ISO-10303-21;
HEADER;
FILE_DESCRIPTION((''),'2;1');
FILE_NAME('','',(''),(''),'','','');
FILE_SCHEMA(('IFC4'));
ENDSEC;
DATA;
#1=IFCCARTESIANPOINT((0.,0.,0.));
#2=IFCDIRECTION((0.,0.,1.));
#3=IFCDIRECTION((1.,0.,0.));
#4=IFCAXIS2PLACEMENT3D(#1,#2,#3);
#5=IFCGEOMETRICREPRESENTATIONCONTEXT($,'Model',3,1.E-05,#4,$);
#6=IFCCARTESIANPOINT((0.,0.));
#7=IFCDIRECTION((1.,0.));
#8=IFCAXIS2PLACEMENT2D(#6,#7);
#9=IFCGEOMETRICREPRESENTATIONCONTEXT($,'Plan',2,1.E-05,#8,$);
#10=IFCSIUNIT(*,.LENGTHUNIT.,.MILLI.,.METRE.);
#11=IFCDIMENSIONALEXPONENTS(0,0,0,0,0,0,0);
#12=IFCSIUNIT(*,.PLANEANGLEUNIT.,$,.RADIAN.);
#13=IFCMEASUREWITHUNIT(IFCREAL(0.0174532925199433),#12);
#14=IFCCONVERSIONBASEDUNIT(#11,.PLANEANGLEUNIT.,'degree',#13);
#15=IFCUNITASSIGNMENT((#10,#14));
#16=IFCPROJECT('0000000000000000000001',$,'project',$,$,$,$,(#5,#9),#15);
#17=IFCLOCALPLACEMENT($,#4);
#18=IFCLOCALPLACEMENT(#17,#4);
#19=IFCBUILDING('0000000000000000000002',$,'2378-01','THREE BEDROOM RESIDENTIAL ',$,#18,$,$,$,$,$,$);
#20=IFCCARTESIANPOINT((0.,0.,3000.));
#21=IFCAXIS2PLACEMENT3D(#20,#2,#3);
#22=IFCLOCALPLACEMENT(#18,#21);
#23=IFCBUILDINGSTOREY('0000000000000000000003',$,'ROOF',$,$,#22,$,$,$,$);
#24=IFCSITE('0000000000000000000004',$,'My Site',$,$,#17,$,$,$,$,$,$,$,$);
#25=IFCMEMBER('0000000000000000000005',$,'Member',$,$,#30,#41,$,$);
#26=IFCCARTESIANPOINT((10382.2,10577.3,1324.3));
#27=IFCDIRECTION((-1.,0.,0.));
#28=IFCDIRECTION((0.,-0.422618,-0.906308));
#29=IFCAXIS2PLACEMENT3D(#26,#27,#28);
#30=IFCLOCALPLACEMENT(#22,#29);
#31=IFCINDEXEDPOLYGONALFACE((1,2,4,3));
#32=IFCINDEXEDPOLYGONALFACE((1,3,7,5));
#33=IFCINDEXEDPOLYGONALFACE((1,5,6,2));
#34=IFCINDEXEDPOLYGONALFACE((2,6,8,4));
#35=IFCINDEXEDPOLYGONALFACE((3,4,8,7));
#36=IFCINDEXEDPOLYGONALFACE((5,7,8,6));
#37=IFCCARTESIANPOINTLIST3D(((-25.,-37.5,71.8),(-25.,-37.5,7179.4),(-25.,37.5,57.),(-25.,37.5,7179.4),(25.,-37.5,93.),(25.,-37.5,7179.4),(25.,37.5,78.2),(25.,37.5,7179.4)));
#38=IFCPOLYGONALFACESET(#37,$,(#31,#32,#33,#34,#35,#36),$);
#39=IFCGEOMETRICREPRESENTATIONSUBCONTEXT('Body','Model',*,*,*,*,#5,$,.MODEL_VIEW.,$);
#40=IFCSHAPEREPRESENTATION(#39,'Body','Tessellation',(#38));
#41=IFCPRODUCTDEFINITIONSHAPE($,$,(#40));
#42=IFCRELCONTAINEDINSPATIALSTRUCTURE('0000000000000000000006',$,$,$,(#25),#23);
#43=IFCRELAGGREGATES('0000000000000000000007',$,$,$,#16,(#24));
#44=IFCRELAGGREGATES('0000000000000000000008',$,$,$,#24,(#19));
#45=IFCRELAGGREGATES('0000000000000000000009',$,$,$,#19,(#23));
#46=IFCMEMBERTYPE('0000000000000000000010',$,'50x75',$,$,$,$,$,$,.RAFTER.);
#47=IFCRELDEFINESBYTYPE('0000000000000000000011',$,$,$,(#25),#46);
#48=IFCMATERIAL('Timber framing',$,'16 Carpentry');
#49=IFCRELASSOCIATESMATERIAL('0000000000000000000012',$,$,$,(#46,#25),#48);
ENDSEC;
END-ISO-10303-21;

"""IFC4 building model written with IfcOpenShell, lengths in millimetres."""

from ifc_helpers import new_model, entity, si_unit, converted_unit, frame, origin_with_axes, origin_2d_with_axis, place, context, subcontext, project, spatial, rectangle, extrude, clip, halfspace, material, material_profile, profile_set, profile_usage, type_object, element, save


model = new_model("IFC4")

# Units and contexts
model_context = context("Model", 3, precision=1e-05, world=origin_with_axes())
plan_context = context("Plan", 2, precision=1e-05, world=origin_2d_with_axis())
body_context = subcontext(model_context, "Body", "Model", "MODEL_VIEW")
ifc_project = project(units=[si_unit("LENGTHUNIT", "METRE", prefix="MILLI"), converted_unit("PLANEANGLEUNIT", "degree", entity("IfcReal", 0.0174532925199433), si_unit("PLANEANGLEUNIT", "RADIAN"), dimensions=[0, 0, 0, 0, 0, 0, 0])], contexts=[model_context, plan_context])

# Site, building, storey
site_placement = place(None, origin_with_axes())
site = spatial("IfcSite", under=ifc_project, at=site_placement, Name="My Site")
building_placement = place(site_placement, origin_with_axes())
building = spatial("IfcBuilding", under=site, at=building_placement, Name="2378-01", Description="THREE BEDROOM RESIDENTIAL ")
storey_placement = place(building_placement, frame((0.0, 0.0, 3000.0), z_axis=(0.0, 0.0, 1.0), x_axis=(1.0, 0.0, 0.0)))
storey = spatial("IfcBuildingStorey", under=building, at=storey_placement, Name="ROOF")

# Member
ifc_material_1 = material(Name="Timber framing", Category="16 Carpentry")
ifc_material_profile_1 = material_profile(ifc_material_1, rectangle(XDim=50.0, YDim=75.0), Name="Lumber2", Category="Substrate", Priority=2)
ifc_profile_set_1 = profile_set([ifc_material_profile_1])
member_type_1 = type_object("IfcMemberType", Name="50x75", PredefinedType="RAFTER", material=ifc_profile_set_1)
ifc_profile_usage_1 = profile_usage(ifc_profile_set_1, cardinal=5)
member_1_placement = place(storey_placement, frame((10382.2, 10577.3, 1324.3), z_axis=(-1.0, 0.0, 0.0), x_axis=(0.0, -0.422618, -0.906308)))
element("IfcMember", 1, at=member_1_placement, inside=storey, type_object=member_type_1, material=ifc_profile_usage_1, Name="Member", context=body_context, shape_type="Clipping", body=[
    clip(extrude(rectangle(XDim=50.0, YDim=75.0), origin_with_axes(), (0.0, 0.0, 1.0), 7179.4), halfspace(frame((919.9, 2011.4, 67.4), z_axis=(0.383022, -0.178606, -0.906308), x_axis=(-0.422618, -0.906308, 0.0)), False)),
])

save(model, "model.ifc")
